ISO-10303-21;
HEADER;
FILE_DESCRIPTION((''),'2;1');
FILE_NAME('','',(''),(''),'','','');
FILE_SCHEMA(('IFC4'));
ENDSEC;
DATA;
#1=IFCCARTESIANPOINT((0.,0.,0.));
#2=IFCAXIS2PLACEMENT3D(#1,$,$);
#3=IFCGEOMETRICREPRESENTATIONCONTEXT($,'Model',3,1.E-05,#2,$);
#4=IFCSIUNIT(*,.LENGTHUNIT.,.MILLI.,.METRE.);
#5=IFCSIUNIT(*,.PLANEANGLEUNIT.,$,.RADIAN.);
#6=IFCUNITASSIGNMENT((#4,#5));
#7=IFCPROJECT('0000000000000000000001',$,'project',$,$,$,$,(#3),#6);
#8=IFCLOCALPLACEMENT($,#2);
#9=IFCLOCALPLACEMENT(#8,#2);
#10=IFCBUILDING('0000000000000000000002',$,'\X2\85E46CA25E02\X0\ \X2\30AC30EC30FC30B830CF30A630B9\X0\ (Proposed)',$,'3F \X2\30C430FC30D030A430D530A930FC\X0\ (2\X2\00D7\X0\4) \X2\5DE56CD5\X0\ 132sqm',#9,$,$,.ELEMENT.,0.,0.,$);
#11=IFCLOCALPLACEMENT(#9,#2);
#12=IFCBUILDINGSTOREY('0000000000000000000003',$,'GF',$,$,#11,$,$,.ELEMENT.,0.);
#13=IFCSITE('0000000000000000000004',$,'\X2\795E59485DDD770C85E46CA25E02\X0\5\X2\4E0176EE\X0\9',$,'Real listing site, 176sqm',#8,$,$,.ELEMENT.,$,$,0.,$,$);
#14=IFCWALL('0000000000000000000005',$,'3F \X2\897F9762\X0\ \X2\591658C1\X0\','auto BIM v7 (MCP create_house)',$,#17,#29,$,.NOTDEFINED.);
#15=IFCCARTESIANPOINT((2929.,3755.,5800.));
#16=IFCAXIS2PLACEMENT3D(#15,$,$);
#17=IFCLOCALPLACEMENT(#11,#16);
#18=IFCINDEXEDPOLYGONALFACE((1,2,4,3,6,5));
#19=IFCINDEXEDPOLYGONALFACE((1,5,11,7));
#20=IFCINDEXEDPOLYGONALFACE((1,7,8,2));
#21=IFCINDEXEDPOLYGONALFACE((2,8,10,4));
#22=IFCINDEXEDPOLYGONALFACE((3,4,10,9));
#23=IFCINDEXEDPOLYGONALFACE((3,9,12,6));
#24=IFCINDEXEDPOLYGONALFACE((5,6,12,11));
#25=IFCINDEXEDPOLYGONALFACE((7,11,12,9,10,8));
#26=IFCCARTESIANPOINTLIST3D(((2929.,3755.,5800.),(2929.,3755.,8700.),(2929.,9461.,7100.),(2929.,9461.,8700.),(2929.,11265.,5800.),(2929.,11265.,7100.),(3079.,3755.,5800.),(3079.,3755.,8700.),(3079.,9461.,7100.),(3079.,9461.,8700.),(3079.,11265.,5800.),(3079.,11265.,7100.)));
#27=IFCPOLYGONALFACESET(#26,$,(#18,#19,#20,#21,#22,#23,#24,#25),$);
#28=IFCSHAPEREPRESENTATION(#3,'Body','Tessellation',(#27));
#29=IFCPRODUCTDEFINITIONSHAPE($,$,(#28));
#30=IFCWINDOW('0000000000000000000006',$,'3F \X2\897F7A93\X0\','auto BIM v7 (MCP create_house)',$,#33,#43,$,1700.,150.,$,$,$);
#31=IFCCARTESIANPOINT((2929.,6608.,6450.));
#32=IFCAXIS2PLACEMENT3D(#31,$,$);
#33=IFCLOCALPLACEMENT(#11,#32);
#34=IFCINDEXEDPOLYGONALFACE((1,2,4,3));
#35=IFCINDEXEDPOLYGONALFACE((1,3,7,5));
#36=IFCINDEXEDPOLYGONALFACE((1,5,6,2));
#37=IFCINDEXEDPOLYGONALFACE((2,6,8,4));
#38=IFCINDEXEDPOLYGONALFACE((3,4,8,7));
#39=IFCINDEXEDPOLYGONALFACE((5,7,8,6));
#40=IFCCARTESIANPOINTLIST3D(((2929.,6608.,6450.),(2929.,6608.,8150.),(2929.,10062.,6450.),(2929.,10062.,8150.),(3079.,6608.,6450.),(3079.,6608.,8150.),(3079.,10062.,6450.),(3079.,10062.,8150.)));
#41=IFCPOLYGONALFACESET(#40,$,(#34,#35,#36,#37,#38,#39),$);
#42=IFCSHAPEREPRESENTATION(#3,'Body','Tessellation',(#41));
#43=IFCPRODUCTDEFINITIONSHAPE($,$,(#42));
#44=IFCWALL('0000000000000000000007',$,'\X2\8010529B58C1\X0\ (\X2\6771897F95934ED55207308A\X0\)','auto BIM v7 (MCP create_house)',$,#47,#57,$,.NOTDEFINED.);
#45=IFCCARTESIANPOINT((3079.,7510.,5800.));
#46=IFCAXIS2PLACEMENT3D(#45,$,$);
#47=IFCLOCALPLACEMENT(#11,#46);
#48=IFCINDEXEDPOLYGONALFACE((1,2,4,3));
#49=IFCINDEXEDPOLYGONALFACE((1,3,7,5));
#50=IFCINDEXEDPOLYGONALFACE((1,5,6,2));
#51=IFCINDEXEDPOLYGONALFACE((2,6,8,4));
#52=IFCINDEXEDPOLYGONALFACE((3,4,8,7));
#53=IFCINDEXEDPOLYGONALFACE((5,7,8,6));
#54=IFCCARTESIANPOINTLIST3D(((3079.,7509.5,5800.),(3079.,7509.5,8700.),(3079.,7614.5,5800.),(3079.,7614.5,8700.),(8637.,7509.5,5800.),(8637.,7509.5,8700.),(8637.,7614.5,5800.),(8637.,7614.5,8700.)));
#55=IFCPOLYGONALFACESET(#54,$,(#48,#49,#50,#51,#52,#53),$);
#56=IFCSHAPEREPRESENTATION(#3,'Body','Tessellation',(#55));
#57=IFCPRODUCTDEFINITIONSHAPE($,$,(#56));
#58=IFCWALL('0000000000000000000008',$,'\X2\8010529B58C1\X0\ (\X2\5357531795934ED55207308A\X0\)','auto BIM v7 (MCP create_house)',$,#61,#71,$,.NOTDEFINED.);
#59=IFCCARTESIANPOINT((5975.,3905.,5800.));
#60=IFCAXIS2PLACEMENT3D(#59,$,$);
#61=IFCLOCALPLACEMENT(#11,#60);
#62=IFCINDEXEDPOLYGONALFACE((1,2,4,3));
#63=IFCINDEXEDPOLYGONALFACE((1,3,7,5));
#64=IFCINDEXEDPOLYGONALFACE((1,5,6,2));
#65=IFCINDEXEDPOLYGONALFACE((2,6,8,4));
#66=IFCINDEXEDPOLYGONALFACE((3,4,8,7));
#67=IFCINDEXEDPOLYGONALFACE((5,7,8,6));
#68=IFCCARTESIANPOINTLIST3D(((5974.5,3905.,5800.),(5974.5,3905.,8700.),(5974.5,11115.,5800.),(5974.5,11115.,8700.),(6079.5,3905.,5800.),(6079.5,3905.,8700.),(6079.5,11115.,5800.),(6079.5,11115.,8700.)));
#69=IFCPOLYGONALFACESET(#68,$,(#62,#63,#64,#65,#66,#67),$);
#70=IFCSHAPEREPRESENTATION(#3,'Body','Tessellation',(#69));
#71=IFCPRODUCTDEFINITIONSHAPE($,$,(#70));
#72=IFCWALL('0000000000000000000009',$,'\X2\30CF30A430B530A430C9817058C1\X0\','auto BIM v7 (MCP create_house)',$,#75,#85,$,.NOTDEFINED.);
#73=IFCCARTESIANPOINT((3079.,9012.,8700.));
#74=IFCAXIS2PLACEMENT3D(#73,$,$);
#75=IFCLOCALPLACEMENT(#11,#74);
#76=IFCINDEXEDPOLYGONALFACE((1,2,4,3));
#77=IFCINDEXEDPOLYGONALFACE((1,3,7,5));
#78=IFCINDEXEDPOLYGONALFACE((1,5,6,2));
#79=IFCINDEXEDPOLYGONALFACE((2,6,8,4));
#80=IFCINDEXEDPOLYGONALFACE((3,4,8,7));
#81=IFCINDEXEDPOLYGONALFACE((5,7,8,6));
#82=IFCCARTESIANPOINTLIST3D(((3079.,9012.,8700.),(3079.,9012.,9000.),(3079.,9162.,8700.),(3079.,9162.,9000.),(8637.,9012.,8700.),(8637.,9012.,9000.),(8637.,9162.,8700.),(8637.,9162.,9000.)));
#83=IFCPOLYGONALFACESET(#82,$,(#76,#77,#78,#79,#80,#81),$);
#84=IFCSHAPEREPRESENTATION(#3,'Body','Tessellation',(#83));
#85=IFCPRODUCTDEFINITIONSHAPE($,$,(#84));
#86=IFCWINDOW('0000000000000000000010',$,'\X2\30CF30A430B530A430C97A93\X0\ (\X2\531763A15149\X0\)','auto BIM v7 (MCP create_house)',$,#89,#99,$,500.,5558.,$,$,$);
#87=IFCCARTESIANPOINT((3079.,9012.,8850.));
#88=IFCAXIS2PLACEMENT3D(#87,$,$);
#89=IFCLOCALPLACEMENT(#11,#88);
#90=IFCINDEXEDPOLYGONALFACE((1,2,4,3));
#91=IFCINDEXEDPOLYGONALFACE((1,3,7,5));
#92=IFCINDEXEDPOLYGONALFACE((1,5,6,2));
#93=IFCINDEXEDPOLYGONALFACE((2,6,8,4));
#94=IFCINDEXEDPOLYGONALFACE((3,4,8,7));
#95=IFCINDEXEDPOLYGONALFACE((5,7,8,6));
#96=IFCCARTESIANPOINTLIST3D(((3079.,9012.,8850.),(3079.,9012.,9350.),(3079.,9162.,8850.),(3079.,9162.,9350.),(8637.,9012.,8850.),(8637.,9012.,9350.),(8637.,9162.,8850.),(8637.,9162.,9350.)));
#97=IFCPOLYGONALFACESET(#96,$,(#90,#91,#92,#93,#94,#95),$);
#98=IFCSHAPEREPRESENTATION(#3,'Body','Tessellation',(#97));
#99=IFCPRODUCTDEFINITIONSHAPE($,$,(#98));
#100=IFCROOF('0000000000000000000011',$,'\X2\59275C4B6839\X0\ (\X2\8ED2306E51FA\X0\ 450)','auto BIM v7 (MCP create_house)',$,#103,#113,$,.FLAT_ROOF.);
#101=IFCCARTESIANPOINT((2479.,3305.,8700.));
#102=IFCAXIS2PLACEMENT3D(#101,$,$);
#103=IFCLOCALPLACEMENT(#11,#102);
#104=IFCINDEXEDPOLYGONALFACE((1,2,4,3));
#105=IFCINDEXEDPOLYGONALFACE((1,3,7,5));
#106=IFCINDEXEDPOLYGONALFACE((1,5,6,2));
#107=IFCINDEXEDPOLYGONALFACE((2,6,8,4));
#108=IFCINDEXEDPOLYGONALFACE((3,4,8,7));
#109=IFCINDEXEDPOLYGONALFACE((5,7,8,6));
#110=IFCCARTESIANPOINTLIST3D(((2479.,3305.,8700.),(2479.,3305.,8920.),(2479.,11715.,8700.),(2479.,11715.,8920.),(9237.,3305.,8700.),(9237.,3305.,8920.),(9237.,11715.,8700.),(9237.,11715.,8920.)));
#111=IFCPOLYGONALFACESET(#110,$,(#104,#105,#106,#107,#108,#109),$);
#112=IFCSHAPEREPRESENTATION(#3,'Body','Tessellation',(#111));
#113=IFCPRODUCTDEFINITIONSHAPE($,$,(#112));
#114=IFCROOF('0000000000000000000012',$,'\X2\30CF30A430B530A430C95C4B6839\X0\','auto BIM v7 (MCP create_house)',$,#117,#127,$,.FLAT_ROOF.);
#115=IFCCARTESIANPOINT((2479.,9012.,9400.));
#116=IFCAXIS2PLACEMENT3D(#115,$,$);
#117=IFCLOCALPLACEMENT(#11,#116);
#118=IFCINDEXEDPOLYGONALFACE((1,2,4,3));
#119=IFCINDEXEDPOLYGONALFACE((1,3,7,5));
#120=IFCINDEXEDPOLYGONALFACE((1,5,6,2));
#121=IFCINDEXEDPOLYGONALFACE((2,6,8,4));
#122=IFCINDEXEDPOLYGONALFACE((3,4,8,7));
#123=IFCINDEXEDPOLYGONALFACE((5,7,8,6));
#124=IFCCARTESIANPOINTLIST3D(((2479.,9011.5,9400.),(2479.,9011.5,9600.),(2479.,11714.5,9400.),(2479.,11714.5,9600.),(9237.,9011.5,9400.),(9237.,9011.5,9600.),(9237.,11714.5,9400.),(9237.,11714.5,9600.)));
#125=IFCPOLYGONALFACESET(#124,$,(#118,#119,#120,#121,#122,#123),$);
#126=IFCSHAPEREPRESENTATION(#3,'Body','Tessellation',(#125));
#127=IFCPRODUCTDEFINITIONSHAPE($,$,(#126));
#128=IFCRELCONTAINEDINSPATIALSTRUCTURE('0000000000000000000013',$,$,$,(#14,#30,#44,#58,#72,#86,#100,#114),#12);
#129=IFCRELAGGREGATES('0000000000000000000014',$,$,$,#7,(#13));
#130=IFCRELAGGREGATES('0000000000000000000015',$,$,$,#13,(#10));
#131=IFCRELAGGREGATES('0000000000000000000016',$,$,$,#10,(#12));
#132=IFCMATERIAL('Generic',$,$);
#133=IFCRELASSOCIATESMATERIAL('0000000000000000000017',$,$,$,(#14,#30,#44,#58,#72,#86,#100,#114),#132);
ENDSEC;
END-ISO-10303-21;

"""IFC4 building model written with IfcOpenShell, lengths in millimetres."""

from ifc_helpers import new_model, si_unit, frame, frame_2d, origin, place, context, project, spatial, rectangle, extrude, material, element, fill, save


model = new_model("IFC4")

# Units and contexts
model_context = context("Model", 3, precision=1e-05, world=origin())
ifc_project = project(units=[si_unit("LENGTHUNIT", "METRE", prefix="MILLI"), si_unit("PLANEANGLEUNIT", "RADIAN")], contexts=[model_context])

# Site, building, storey
site_placement = place(None, origin())
site = spatial("IfcSite", under=ifc_project, at=site_placement, Name="神奈川県藤沢市5丁目9", ObjectType="Real listing site, 176sqm", CompositionType="ELEMENT", RefElevation=0.0)
building_placement = place(site_placement, origin())
building = spatial("IfcBuilding", under=site, at=building_placement, Name="藤沢市 ガレージハウス (Proposed)", ObjectType="3F ツーバイフォー (2×4) 工法 132sqm", CompositionType="ELEMENT", ElevationOfRefHeight=0.0, ElevationOfTerrain=0.0)
storey_placement = place(building_placement, origin())
storey = spatial("IfcBuildingStorey", under=building, at=storey_placement, Name="GF", CompositionType="ELEMENT", Elevation=0.0)

# Shared definitions
ifc_material = material(Name="Generic")

# Wall, opening, window
wall_1_placement = place(storey_placement, frame((2929.0, 3755.0, 5800.0)))
wall_1 = element("IfcWall", 1, at=wall_1_placement, inside=storey, material=ifc_material, Name="3F 西面 外壁", Description="auto BIM v7 (MCP create_house)", PredefinedType="NOTDEFINED", context=model_context, shape_type="SweptSolid", body=[
    extrude(rectangle(XDim=150.0, YDim=7510.0, at=frame_2d((75.0, 3755.0))), frame((2929.0, 3755.0, 5800.0)), (0.0, 0.0, 1.0), 2900.0),
])
opening_1_placement = place(storey_placement, frame((2929.0, 6608.0, 6450.0)))
opening_1 = element("IfcOpeningElement", 2, at=opening_1_placement, cuts=wall_1, PredefinedType="NOTDEFINED", context=model_context, shape_type="SweptSolid", body=[
    extrude(rectangle(XDim=150.0, YDim=3454.0, at=frame_2d((75.0, 1727.0))), frame((2929.0, 6608.0, 6450.0)), (0.0, 0.0, 1.0), 1700.0),
])
window_1_placement = place(storey_placement, frame((2929.0, 6608.0, 6450.0)))
window_1 = element("IfcWindow", 3, at=window_1_placement, inside=storey, material=ifc_material, Name="3F 西窓", Description="auto BIM v7 (MCP create_house)", OverallHeight=1700.0, OverallWidth=150.0, context=model_context, shape_type="SweptSolid", body=[
    extrude(rectangle(XDim=150.0, YDim=3454.0, at=frame_2d((75.0, 1727.0))), frame((2929.0, 6608.0, 6450.0)), (0.0, 0.0, 1.0), 1700.0),
])
fill(opening_1, window_1)

# Walls
wall_2_placement = place(storey_placement, frame((3079.0, 7510.0, 5800.0)))
element("IfcWall", 4, at=wall_2_placement, inside=storey, material=ifc_material, Name="耐力壁 (東西間仕切り)", Description="auto BIM v7 (MCP create_house)", PredefinedType="NOTDEFINED", context=model_context, shape_type="SweptSolid", body=[
    extrude(rectangle(XDim=5558.0, YDim=105.0, at=frame_2d((2779.0, 52.0))), frame((3079.0, 7510.0, 5800.0)), (0.0, 0.0, 1.0), 2900.0),
])
wall_3_placement = place(storey_placement, frame((5975.0, 3905.0, 5800.0)))
element("IfcWall", 5, at=wall_3_placement, inside=storey, material=ifc_material, Name="耐力壁 (南北間仕切り)", Description="auto BIM v7 (MCP create_house)", PredefinedType="NOTDEFINED", context=model_context, shape_type="SweptSolid", body=[
    extrude(rectangle(XDim=105.0, YDim=7210.0, at=frame_2d((52.0, 3605.0))), frame((5975.0, 3905.0, 5800.0)), (0.0, 0.0, 1.0), 2900.0),
])

# Wall, opening, window
wall_4_placement = place(storey_placement, frame((3079.0, 9012.0, 8700.0)))
wall_4 = element("IfcWall", 6, at=wall_4_placement, inside=storey, material=ifc_material, Name="ハイサイド腰壁", Description="auto BIM v7 (MCP create_house)", PredefinedType="NOTDEFINED", context=model_context, shape_type="SweptSolid", body=[
    extrude(rectangle(XDim=5558.0, YDim=150.0, at=frame_2d((2779.0, 75.0))), frame((3079.0, 9012.0, 8700.0)), (0.0, 0.0, 1.0), 700.0),
])
opening_2_placement = place(storey_placement, frame((3079.0, 9012.0, 8850.0)))
opening_2 = element("IfcOpeningElement", 7, at=opening_2_placement, cuts=wall_4, PredefinedType="NOTDEFINED", context=model_context, shape_type="SweptSolid", body=[
    extrude(rectangle(XDim=5558.0, YDim=150.0, at=frame_2d((2779.0, 75.0))), frame((3079.0, 9012.0, 8850.0)), (0.0, 0.0, 1.0), 500.0),
])
window_2_placement = place(storey_placement, frame((3079.0, 9012.0, 8850.0)))
window_2 = element("IfcWindow", 8, at=window_2_placement, inside=storey, material=ifc_material, Name="ハイサイド窓 (北採光)", Description="auto BIM v7 (MCP create_house)", OverallHeight=500.0, OverallWidth=5558.0, context=model_context, shape_type="SweptSolid", body=[
    extrude(rectangle(XDim=5558.0, YDim=150.0, at=frame_2d((2779.0, 75.0))), frame((3079.0, 9012.0, 8850.0)), (0.0, 0.0, 1.0), 500.0),
])
fill(opening_2, window_2)

# Roofs
roof_1_placement = place(storey_placement, frame((2479.0, 3305.0, 8700.0)))
element("IfcRoof", 9, at=roof_1_placement, inside=storey, material=ifc_material, Name="大屋根 (軒の出 450)", Description="auto BIM v7 (MCP create_house)", PredefinedType="FLAT_ROOF", context=model_context, shape_type="SweptSolid", body=[
    extrude(rectangle(XDim=6758.0, YDim=8410.0, at=frame_2d((3379.0, 4205.0))), frame((2479.0, 3305.0, 8700.0)), (0.0, 0.0, 1.0), 220.0),
])
roof_2_placement = place(storey_placement, frame((2479.0, 9012.0, 9400.0)))
element("IfcRoof", 10, at=roof_2_placement, inside=storey, material=ifc_material, Name="ハイサイド屋根", Description="auto BIM v7 (MCP create_house)", PredefinedType="FLAT_ROOF", context=model_context, shape_type="SweptSolid", body=[
    extrude(rectangle(XDim=6758.0, YDim=2703.0, at=frame_2d((3379.0, 1351.0))), frame((2479.0, 9012.0, 9400.0)), (0.0, 0.0, 1.0), 200.0),
])

save(model, "model.ifc")
